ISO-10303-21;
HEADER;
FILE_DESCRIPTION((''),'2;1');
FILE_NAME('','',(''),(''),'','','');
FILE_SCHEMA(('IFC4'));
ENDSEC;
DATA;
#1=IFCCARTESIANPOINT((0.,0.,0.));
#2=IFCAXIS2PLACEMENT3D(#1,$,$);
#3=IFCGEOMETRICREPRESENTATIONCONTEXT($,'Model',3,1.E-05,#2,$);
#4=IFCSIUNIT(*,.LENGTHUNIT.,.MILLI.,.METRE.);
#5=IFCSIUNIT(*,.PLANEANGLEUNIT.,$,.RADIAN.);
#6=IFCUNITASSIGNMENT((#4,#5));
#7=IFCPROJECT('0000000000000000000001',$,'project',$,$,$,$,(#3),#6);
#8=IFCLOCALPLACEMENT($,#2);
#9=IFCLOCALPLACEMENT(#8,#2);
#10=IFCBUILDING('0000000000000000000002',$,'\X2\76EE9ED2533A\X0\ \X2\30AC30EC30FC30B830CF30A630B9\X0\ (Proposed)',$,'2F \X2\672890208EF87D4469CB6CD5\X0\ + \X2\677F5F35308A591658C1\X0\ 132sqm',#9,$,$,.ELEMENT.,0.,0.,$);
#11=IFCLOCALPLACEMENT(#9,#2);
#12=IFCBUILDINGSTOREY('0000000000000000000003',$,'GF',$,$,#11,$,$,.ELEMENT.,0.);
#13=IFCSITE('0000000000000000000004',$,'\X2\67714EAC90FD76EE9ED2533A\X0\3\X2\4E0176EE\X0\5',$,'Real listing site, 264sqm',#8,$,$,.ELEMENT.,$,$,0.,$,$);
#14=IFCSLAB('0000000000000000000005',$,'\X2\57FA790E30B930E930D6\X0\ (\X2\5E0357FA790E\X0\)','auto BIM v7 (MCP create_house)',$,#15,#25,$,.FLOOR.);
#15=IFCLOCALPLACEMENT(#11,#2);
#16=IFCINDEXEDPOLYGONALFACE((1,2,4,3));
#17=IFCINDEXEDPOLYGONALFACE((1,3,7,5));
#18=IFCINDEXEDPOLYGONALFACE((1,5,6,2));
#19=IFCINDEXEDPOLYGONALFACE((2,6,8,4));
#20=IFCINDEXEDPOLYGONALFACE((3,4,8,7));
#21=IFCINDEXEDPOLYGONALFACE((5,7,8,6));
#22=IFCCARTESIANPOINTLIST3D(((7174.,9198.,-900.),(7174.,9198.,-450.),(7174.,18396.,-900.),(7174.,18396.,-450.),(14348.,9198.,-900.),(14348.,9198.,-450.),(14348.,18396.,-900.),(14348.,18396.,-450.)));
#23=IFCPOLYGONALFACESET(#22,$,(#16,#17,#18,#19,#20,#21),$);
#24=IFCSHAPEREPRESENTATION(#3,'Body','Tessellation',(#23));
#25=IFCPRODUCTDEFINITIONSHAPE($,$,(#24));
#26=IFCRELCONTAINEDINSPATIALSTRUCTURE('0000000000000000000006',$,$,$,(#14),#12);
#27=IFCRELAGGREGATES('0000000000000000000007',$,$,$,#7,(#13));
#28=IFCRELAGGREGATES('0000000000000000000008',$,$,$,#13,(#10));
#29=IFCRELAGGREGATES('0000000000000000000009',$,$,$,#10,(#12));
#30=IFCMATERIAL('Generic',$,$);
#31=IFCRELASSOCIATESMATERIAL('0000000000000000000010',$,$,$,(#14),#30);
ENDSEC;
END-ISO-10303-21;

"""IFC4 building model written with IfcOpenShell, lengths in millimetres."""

from ifc_helpers import new_model, si_unit, frame, frame_2d, origin, place, context, project, spatial, rectangle, extrude, material, element, save


model = new_model("IFC4")

# Units and contexts
model_context = context("Model", 3, precision=1e-05, world=origin())
ifc_project = project(units=[si_unit("LENGTHUNIT", "METRE", prefix="MILLI"), si_unit("PLANEANGLEUNIT", "RADIAN")], contexts=[model_context])

# Site, building, storey
site_placement = place(None, origin())
site = spatial("IfcSite", under=ifc_project, at=site_placement, Name="東京都目黒区3丁目5", ObjectType="Real listing site, 264sqm", CompositionType="ELEMENT", RefElevation=0.0)
building_placement = place(site_placement, origin())
building = spatial("IfcBuilding", under=site, at=building_placement, Name="目黒区 ガレージハウス (Proposed)", ObjectType="2F 木造軸組構法 + 板張り外壁 132sqm", CompositionType="ELEMENT", ElevationOfRefHeight=0.0, ElevationOfTerrain=0.0)
storey_placement = place(building_placement, origin())
storey = spatial("IfcBuildingStorey", under=building, at=storey_placement, Name="GF", CompositionType="ELEMENT", Elevation=0.0)

# Slab
ifc_material = material(Name="Generic")
slab_1_placement = place(storey_placement, frame((3587.0, 4599.0, -450.0)))
element("IfcSlab", 1, at=slab_1_placement, inside=storey, material=ifc_material, Name="基礎スラブ (布基礎)", Description="auto BIM v7 (MCP create_house)", PredefinedType="FLOOR", context=model_context, shape_type="SweptSolid", body=[
    extrude(rectangle(XDim=7174.0, YDim=9198.0, at=frame_2d((3587.0, 4599.0))), frame((3587.0, 4599.0, -450.0)), (0.0, 0.0, 1.0), 450.0),
])

save(model, "model.ifc")
